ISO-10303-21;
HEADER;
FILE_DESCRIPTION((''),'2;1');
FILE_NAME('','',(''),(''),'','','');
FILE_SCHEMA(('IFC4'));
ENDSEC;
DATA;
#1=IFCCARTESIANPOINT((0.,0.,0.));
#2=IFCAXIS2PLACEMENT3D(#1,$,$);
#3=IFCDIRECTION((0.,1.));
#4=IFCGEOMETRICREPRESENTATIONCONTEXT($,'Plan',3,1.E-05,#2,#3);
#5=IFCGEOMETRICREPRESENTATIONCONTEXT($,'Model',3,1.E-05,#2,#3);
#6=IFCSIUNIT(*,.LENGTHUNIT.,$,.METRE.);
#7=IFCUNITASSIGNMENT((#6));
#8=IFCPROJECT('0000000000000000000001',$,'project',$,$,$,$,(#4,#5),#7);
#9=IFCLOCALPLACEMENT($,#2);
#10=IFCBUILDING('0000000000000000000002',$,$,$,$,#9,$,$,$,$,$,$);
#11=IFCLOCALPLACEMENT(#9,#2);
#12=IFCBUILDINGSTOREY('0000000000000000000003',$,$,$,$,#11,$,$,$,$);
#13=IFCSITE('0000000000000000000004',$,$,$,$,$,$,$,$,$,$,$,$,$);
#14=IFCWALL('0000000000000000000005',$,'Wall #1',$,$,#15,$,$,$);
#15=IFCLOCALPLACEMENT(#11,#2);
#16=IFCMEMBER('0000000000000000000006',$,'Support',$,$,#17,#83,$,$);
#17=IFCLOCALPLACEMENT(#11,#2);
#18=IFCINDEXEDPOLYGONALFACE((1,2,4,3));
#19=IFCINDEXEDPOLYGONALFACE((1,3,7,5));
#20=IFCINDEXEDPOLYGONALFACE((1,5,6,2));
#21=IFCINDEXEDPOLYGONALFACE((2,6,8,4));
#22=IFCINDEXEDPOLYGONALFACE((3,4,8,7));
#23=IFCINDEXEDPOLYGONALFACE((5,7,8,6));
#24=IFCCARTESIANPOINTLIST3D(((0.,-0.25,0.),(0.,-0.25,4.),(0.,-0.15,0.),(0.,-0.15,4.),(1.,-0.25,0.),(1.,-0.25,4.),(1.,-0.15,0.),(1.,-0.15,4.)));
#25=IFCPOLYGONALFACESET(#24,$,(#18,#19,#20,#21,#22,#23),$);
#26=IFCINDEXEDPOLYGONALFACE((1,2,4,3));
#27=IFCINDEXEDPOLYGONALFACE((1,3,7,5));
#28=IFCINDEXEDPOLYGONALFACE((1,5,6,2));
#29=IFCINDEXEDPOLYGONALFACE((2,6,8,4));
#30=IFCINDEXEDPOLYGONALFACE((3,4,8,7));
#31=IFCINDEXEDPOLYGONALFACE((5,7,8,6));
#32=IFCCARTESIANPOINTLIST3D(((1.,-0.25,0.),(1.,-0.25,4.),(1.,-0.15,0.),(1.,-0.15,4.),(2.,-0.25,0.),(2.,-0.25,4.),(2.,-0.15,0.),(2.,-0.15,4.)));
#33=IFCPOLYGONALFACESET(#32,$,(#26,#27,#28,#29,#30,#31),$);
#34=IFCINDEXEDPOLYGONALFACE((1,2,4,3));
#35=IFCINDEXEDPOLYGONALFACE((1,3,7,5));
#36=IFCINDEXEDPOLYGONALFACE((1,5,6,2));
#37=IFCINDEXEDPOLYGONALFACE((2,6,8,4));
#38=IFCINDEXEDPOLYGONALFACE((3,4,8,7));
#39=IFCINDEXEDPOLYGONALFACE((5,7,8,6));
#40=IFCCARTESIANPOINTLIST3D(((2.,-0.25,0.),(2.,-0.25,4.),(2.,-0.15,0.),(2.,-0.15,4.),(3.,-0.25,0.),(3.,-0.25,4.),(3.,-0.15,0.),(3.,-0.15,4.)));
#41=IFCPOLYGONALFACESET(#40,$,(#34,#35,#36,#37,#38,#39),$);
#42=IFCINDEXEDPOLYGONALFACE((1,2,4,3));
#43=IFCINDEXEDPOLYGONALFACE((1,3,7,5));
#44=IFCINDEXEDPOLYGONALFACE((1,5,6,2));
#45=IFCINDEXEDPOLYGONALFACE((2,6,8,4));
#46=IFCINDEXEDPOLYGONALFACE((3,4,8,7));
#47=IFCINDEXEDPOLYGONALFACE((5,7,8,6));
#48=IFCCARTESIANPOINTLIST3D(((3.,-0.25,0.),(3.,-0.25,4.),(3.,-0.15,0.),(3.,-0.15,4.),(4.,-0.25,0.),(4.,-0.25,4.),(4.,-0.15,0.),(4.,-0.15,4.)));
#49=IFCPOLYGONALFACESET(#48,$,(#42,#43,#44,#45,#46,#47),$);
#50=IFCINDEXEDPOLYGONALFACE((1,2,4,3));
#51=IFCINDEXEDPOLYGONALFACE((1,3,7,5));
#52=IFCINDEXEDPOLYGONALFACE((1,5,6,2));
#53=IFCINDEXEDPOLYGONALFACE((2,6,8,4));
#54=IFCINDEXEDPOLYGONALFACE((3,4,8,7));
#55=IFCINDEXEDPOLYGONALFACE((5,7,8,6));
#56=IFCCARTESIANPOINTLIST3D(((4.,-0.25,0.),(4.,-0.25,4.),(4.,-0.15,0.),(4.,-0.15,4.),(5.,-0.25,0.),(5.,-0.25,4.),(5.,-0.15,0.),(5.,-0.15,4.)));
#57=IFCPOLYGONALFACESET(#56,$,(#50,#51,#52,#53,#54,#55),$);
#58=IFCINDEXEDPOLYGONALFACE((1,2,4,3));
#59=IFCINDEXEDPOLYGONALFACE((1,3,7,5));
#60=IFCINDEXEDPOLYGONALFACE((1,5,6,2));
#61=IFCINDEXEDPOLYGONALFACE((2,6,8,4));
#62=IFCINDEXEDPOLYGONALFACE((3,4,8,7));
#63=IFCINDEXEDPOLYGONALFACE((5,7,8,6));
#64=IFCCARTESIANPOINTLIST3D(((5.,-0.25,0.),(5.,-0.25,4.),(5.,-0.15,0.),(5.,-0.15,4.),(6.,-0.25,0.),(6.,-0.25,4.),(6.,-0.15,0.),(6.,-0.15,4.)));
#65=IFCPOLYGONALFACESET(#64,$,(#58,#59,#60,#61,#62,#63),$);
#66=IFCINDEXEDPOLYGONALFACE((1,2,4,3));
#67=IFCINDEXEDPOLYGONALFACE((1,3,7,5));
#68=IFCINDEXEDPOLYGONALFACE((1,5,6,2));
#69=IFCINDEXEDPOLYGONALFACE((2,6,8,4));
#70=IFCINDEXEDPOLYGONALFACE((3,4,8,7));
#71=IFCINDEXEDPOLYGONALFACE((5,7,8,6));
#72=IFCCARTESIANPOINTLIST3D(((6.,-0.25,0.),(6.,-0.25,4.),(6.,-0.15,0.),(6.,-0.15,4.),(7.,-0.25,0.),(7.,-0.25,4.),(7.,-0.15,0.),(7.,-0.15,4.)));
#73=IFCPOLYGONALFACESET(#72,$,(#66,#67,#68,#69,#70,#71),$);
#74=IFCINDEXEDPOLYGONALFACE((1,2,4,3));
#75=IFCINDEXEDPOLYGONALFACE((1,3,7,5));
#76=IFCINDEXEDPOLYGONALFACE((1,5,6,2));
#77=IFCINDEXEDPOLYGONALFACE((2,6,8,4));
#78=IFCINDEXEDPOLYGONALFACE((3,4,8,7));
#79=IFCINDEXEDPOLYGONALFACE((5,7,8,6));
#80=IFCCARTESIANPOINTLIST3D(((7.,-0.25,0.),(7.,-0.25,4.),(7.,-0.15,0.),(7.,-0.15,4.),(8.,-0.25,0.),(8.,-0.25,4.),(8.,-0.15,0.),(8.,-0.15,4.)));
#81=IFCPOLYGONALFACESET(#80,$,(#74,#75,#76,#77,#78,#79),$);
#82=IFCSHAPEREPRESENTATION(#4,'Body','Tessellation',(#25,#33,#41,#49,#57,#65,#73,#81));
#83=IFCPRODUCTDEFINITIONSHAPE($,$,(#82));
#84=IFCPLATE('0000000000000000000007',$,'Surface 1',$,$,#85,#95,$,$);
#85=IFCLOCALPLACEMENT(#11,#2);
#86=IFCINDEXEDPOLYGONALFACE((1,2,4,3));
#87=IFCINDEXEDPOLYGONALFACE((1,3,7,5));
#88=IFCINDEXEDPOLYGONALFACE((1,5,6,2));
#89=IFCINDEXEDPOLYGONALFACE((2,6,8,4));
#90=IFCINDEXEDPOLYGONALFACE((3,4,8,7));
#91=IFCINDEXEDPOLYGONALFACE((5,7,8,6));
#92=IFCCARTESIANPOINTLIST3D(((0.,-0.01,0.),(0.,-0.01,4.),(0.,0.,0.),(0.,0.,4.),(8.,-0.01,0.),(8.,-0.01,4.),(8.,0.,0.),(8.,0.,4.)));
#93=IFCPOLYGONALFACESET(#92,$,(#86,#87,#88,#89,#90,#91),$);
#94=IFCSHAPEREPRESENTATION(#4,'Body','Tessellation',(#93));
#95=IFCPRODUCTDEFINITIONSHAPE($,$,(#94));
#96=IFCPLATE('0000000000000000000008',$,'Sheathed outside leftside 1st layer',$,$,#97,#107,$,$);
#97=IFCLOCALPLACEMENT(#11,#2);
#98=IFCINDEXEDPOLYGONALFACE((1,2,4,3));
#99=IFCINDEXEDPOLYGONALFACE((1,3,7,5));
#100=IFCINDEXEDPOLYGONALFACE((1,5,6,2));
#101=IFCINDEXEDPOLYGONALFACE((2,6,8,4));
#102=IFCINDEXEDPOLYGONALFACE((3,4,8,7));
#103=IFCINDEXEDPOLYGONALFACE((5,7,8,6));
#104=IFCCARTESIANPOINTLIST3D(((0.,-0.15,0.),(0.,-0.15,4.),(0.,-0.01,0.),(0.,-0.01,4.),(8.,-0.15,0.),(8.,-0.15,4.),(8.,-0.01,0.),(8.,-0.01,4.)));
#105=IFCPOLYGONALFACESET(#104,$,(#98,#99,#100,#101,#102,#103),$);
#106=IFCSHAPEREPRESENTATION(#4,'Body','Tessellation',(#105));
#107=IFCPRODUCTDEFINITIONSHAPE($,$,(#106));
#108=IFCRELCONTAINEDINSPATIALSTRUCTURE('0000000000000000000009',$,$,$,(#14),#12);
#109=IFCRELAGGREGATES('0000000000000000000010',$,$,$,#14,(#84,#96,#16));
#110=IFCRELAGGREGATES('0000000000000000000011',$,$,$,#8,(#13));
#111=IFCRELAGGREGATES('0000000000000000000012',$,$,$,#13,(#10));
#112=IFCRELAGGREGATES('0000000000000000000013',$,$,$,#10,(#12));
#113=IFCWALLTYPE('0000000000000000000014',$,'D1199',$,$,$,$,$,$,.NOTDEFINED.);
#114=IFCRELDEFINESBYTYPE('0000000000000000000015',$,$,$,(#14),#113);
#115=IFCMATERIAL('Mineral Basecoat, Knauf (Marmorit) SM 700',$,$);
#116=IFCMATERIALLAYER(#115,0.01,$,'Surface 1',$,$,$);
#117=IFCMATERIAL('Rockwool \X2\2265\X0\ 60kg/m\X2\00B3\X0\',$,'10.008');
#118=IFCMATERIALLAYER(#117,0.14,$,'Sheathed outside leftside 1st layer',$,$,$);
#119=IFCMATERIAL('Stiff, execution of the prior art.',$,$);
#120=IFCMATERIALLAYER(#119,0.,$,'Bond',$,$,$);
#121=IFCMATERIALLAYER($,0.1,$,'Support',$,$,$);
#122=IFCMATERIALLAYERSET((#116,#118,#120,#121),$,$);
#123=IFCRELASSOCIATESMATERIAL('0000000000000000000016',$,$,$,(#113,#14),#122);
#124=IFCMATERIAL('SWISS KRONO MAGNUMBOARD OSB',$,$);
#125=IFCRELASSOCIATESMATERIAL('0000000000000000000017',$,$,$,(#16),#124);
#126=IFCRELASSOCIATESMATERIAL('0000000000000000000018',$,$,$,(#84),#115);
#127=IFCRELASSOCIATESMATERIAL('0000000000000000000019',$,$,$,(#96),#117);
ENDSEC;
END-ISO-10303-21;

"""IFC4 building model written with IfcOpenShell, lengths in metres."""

from ifc_helpers import new_model, si_unit, direction, frame, frame_2d, origin, origin_with_axes, place, context, project, spatial, rectangle, extrude, material, layer, layer_set, type_object, element, aggregate, save


model = new_model("IFC4")

# Units and contexts
plan_context = context("Plan", 3, precision=1e-05, world=origin(), true_north=direction((0.0, 1.0)))
model_context = context("Model", 3, precision=1e-05, world=origin(), true_north=direction((0.0, 1.0)))
ifc_project = project(units=[si_unit("LENGTHUNIT", "METRE")], contexts=[plan_context, model_context])

# Site, building, storey
site = spatial("IfcSite", under=ifc_project)
building_placement = place(None, origin())
building = spatial("IfcBuilding", under=site, at=building_placement)
storey_placement = place(building_placement, origin())
storey = spatial("IfcBuildingStorey", under=building, at=storey_placement)

# Wall, member, plates
ifc_material_1 = material(Name="Mineral Basecoat, Knauf (Marmorit) SM 700")
ifc_layer_1 = layer(ifc_material_1, 0.01, Name="Surface 1")
ifc_material_2 = material(Name="Rockwool ≥ 60kg/m³", Category="10.008")
ifc_layer_2 = layer(ifc_material_2, 0.14, Name="Sheathed outside leftside 1st layer")
ifc_material_3 = material(Name="Stiff, execution of the prior art.")
ifc_layer_3 = layer(ifc_material_3, 0.0, Name="Bond")
ifc_layer_4 = layer(None, 0.1, Name="Support")
ifc_layer_set = layer_set([ifc_layer_1, ifc_layer_2, ifc_layer_3, ifc_layer_4])
wall_type = type_object("IfcWallType", Name="D1199", PredefinedType="NOTDEFINED", material=ifc_layer_set)
wall_placement = place(None, frame((0.0, 0.0, 0.0), z_axis=(0.0, -1.0, 0.0), x_axis=(1.0, 0.0, 0.0)))
wall = element("IfcWall", 1, at=wall_placement, inside=storey, type_object=wall_type, material=ifc_layer_set, Name="Wall #1")
ifc_material_4 = material(Name="SWISS KRONO MAGNUMBOARD OSB")
member_placement = place(wall_placement, origin())
member = element("IfcMember", 2, at=member_placement, material=ifc_material_4, Name="Support", context=plan_context, shape_type="SweptSolid", body=[
    extrude(rectangle(XDim=1.0, YDim=0.1, at=frame_2d((0.5, 0.05), x_axis=(1.0, 0.0))), frame((0.0, 4.0, 0.15), z_axis=(0.0, -1.0, 0.0), x_axis=(1.0, 0.0, 0.0)), (0.0, 0.0, 1.0), 4.0),
    extrude(rectangle(XDim=1.0, YDim=0.1, at=frame_2d((0.5, 0.05), x_axis=(1.0, 0.0))), frame((1.0, 4.0, 0.15), z_axis=(0.0, -1.0, 0.0), x_axis=(1.0, 0.0, 0.0)), (0.0, 0.0, 1.0), 4.0),
    extrude(rectangle(XDim=1.0, YDim=0.1, at=frame_2d((0.5, 0.05), x_axis=(1.0, 0.0))), frame((2.0, 4.0, 0.15), z_axis=(0.0, -1.0, 0.0), x_axis=(1.0, 0.0, 0.0)), (0.0, 0.0, 1.0), 4.0),
    extrude(rectangle(XDim=1.0, YDim=0.1, at=frame_2d((0.5, 0.05), x_axis=(1.0, 0.0))), frame((3.0, 4.0, 0.15), z_axis=(0.0, -1.0, 0.0), x_axis=(1.0, 0.0, 0.0)), (0.0, 0.0, 1.0), 4.0),
    extrude(rectangle(XDim=1.0, YDim=0.1, at=frame_2d((0.5, 0.05), x_axis=(1.0, 0.0))), frame((4.0, 4.0, 0.15), z_axis=(0.0, -1.0, 0.0), x_axis=(1.0, 0.0, 0.0)), (0.0, 0.0, 1.0), 4.0),
    extrude(rectangle(XDim=1.0, YDim=0.1, at=frame_2d((0.5, 0.05), x_axis=(1.0, 0.0))), frame((5.0, 4.0, 0.15), z_axis=(0.0, -1.0, 0.0), x_axis=(1.0, 0.0, 0.0)), (0.0, 0.0, 1.0), 4.0),
    extrude(rectangle(XDim=1.0, YDim=0.1, at=frame_2d((0.5, 0.05), x_axis=(1.0, 0.0))), frame((6.0, 4.0, 0.15), z_axis=(0.0, -1.0, 0.0), x_axis=(1.0, 0.0, 0.0)), (0.0, 0.0, 1.0), 4.0),
    extrude(rectangle(XDim=1.0, YDim=0.1, at=frame_2d((0.5, 0.05), x_axis=(1.0, 0.0))), frame((7.0, 4.0, 0.15), z_axis=(0.0, -1.0, 0.0), x_axis=(1.0, 0.0, 0.0)), (0.0, 0.0, 1.0), 4.0),
])
plate_1_placement = place(wall_placement, origin())
plate_1 = element("IfcPlate", 3, at=plate_1_placement, material=ifc_material_1, Name="Surface 1", context=plan_context, shape_type="SweptSolid", body=[
    extrude(rectangle(XDim=8.0, YDim=4.0, at=frame_2d((4.0, 2.0), x_axis=(1.0, 0.0))), origin_with_axes(), (0.0, 0.0, 1.0), 0.01),
])
plate_2_placement = place(wall_placement, origin())
plate_2 = element("IfcPlate", 4, at=plate_2_placement, material=ifc_material_2, Name="Sheathed outside leftside 1st layer", context=plan_context, shape_type="SweptSolid", body=[
    extrude(rectangle(XDim=8.0, YDim=4.0, at=frame_2d((4.0, 2.0), x_axis=(1.0, 0.0))), frame((0.0, 0.0, 0.01), z_axis=(0.0, 0.0, 1.0), x_axis=(1.0, 0.0, 0.0)), (0.0, 0.0, 1.0), 0.14),
])
aggregate(wall, [plate_1, plate_2, member])

save(model, "model.ifc")
